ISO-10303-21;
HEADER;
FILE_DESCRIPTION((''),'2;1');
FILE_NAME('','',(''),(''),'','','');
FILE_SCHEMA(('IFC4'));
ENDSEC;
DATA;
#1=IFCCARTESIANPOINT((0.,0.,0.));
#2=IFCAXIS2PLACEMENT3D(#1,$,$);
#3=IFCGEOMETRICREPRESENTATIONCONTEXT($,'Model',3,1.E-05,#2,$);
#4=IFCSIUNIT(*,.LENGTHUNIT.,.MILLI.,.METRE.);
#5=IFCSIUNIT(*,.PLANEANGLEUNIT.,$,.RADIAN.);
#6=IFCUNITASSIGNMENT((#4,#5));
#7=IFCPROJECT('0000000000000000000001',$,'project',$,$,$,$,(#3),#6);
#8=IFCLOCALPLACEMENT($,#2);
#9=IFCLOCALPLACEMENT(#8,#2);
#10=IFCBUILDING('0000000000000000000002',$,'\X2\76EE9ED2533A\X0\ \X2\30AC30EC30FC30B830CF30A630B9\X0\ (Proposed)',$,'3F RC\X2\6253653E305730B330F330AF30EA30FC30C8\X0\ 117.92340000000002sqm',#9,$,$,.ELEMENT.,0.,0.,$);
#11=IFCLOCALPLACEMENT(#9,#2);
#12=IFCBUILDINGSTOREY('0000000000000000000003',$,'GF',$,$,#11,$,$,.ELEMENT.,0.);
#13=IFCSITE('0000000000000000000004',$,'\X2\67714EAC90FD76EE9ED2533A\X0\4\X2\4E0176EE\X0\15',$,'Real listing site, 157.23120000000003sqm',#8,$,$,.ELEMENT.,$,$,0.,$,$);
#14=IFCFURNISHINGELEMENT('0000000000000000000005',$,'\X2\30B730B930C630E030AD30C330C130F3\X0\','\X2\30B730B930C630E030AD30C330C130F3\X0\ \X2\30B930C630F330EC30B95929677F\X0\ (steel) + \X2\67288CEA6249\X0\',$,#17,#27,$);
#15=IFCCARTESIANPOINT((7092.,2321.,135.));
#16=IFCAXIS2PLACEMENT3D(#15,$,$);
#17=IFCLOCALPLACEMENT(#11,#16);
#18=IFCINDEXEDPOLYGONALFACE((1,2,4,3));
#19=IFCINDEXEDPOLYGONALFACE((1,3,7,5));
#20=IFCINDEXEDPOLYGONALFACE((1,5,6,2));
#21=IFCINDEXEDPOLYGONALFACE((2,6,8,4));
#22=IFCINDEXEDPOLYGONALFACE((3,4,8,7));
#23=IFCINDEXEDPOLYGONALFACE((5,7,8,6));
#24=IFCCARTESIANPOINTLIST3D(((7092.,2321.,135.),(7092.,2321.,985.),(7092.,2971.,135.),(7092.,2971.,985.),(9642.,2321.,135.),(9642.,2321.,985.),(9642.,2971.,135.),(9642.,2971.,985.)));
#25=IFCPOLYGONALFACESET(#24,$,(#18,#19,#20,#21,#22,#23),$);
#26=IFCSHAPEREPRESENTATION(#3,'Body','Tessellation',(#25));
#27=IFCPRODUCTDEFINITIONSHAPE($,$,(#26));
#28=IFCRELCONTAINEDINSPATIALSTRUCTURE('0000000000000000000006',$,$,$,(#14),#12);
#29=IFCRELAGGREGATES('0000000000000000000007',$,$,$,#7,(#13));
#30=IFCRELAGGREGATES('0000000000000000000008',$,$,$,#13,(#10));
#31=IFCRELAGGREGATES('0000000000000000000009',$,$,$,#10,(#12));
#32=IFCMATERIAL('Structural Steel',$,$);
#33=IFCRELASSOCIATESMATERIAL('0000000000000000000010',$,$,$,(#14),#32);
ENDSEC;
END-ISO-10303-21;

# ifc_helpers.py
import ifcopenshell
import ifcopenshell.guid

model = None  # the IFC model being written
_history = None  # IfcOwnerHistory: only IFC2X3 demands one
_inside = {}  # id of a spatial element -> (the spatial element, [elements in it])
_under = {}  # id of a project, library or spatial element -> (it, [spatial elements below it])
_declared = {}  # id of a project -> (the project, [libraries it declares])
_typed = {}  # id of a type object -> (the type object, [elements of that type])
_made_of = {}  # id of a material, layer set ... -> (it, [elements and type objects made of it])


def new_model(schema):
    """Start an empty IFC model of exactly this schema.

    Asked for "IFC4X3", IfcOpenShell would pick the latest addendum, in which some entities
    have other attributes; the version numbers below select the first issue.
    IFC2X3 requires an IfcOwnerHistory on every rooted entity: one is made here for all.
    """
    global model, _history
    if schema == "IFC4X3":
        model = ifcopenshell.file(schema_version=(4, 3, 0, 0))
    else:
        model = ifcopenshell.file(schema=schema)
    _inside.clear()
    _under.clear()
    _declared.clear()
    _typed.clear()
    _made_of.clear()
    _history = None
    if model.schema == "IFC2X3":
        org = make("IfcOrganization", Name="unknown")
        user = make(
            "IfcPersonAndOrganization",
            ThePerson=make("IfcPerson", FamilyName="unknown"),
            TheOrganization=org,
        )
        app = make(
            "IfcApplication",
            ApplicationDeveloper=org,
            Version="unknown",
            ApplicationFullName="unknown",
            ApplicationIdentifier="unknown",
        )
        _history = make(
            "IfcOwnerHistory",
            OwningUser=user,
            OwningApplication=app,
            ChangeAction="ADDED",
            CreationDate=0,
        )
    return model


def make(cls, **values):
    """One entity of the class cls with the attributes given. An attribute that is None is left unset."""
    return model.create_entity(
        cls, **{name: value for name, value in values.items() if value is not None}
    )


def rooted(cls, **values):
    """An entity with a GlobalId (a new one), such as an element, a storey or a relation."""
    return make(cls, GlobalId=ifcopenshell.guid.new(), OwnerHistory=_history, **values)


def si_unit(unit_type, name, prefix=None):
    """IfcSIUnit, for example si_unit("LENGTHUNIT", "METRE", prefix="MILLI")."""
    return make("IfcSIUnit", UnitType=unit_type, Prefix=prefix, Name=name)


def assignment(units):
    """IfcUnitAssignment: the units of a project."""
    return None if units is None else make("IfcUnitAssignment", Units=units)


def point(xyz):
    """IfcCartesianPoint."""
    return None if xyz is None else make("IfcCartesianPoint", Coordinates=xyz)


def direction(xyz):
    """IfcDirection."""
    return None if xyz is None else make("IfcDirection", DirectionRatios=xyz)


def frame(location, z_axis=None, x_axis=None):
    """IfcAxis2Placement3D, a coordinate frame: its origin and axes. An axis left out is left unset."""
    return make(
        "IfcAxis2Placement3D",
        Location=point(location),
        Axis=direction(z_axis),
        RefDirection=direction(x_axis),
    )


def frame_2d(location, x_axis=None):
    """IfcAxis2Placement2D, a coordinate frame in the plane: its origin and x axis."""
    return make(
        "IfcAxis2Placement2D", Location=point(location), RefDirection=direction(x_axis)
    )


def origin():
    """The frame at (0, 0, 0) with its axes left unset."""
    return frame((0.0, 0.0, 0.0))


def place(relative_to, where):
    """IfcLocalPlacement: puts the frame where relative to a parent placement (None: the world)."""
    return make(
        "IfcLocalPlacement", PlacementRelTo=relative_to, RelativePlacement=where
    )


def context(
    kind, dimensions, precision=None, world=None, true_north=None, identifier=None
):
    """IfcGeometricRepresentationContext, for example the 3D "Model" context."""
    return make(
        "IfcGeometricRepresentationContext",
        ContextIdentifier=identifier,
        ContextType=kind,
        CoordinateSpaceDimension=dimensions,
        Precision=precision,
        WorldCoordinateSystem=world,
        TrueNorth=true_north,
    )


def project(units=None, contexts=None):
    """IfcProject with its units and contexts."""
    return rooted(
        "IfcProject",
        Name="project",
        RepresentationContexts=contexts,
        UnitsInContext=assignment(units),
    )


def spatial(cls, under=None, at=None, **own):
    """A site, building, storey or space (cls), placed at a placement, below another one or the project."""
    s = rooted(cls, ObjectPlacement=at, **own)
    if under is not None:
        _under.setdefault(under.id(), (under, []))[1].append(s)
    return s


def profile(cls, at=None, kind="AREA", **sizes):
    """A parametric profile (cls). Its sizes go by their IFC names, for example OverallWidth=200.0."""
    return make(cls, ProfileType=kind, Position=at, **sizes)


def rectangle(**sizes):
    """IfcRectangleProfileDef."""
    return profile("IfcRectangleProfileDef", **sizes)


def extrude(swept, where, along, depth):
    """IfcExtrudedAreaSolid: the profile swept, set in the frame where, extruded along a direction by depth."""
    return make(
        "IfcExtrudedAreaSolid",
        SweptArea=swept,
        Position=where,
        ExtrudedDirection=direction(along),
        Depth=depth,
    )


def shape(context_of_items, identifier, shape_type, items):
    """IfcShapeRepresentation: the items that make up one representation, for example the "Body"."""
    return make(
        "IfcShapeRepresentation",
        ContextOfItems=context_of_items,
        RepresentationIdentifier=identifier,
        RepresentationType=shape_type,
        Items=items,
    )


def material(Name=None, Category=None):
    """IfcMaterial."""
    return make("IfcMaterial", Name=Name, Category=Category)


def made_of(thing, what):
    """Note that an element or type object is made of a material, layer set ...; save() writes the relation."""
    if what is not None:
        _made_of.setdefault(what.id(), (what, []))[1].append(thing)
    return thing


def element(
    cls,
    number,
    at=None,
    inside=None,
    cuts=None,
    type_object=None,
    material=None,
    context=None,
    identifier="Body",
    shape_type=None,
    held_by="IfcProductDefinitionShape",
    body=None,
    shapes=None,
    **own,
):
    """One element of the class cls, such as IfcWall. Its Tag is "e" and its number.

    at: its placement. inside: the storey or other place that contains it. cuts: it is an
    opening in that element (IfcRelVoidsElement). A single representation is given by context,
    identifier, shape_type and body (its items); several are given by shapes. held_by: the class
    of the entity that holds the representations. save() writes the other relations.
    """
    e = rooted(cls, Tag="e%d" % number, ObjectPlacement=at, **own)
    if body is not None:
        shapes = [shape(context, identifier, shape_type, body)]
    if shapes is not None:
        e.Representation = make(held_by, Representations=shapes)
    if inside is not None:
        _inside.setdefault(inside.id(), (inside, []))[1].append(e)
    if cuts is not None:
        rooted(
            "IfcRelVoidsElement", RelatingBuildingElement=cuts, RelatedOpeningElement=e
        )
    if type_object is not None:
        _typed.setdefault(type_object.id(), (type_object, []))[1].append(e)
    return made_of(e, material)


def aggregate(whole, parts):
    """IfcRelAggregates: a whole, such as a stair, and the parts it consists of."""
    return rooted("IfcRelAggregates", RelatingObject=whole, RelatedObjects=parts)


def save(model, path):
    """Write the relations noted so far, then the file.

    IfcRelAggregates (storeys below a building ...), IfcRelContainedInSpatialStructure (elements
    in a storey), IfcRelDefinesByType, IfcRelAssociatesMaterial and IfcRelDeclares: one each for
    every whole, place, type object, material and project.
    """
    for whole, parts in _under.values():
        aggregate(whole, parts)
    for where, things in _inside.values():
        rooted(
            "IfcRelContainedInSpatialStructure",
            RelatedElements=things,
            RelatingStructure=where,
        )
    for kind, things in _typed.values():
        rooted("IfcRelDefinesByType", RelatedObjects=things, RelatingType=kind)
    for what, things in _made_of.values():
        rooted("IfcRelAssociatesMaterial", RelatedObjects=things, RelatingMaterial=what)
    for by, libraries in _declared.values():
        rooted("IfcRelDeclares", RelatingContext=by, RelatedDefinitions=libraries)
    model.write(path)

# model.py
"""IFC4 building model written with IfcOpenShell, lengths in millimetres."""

from ifc_helpers import new_model, si_unit, frame, frame_2d, origin, place, context, project, spatial, rectangle, extrude, material, element, save


model = new_model("IFC4")

# Units and contexts
model_context = context("Model", 3, precision=1e-05, world=origin())
ifc_project = project(units=[si_unit("LENGTHUNIT", "METRE", prefix="MILLI"), si_unit("PLANEANGLEUNIT", "RADIAN")], contexts=[model_context])

# Site, building, storey
site_placement = place(None, origin())
site = spatial("IfcSite", under=ifc_project, at=site_placement, Name="東京都目黒区4丁目15", ObjectType="Real listing site, 157.23120000000003sqm", CompositionType="ELEMENT", RefElevation=0.0)
building_placement = place(site_placement, origin())
building = spatial("IfcBuilding", under=site, at=building_placement, Name="目黒区 ガレージハウス (Proposed)", ObjectType="3F RC打放しコンクリート 117.92340000000002sqm", CompositionType="ELEMENT", ElevationOfRefHeight=0.0, ElevationOfTerrain=0.0)
storey_placement = place(building_placement, origin())
storey = spatial("IfcBuildingStorey", under=building, at=storey_placement, Name="GF", CompositionType="ELEMENT", Elevation=0.0)

# Furnishing element
ifc_material_1 = material(Name="Structural Steel")
furnishing_1_placement = place(storey_placement, frame((7092.0, 2321.0, 135.0)))
element("IfcFurnishingElement", 1, at=furnishing_1_placement, inside=storey, material=ifc_material_1, Name="システムキッチン", Description="システムキッチン ステンレス天板 (steel) + 木質扉", context=model_context, shape_type="SweptSolid", body=[
    extrude(rectangle(XDim=2550.0, YDim=650.0, at=frame_2d((1275.0, 325.0))), frame((7092.0, 2321.0, 135.0)), (0.0, 0.0, 1.0), 850.0),
])

save(model, "model.ifc")
